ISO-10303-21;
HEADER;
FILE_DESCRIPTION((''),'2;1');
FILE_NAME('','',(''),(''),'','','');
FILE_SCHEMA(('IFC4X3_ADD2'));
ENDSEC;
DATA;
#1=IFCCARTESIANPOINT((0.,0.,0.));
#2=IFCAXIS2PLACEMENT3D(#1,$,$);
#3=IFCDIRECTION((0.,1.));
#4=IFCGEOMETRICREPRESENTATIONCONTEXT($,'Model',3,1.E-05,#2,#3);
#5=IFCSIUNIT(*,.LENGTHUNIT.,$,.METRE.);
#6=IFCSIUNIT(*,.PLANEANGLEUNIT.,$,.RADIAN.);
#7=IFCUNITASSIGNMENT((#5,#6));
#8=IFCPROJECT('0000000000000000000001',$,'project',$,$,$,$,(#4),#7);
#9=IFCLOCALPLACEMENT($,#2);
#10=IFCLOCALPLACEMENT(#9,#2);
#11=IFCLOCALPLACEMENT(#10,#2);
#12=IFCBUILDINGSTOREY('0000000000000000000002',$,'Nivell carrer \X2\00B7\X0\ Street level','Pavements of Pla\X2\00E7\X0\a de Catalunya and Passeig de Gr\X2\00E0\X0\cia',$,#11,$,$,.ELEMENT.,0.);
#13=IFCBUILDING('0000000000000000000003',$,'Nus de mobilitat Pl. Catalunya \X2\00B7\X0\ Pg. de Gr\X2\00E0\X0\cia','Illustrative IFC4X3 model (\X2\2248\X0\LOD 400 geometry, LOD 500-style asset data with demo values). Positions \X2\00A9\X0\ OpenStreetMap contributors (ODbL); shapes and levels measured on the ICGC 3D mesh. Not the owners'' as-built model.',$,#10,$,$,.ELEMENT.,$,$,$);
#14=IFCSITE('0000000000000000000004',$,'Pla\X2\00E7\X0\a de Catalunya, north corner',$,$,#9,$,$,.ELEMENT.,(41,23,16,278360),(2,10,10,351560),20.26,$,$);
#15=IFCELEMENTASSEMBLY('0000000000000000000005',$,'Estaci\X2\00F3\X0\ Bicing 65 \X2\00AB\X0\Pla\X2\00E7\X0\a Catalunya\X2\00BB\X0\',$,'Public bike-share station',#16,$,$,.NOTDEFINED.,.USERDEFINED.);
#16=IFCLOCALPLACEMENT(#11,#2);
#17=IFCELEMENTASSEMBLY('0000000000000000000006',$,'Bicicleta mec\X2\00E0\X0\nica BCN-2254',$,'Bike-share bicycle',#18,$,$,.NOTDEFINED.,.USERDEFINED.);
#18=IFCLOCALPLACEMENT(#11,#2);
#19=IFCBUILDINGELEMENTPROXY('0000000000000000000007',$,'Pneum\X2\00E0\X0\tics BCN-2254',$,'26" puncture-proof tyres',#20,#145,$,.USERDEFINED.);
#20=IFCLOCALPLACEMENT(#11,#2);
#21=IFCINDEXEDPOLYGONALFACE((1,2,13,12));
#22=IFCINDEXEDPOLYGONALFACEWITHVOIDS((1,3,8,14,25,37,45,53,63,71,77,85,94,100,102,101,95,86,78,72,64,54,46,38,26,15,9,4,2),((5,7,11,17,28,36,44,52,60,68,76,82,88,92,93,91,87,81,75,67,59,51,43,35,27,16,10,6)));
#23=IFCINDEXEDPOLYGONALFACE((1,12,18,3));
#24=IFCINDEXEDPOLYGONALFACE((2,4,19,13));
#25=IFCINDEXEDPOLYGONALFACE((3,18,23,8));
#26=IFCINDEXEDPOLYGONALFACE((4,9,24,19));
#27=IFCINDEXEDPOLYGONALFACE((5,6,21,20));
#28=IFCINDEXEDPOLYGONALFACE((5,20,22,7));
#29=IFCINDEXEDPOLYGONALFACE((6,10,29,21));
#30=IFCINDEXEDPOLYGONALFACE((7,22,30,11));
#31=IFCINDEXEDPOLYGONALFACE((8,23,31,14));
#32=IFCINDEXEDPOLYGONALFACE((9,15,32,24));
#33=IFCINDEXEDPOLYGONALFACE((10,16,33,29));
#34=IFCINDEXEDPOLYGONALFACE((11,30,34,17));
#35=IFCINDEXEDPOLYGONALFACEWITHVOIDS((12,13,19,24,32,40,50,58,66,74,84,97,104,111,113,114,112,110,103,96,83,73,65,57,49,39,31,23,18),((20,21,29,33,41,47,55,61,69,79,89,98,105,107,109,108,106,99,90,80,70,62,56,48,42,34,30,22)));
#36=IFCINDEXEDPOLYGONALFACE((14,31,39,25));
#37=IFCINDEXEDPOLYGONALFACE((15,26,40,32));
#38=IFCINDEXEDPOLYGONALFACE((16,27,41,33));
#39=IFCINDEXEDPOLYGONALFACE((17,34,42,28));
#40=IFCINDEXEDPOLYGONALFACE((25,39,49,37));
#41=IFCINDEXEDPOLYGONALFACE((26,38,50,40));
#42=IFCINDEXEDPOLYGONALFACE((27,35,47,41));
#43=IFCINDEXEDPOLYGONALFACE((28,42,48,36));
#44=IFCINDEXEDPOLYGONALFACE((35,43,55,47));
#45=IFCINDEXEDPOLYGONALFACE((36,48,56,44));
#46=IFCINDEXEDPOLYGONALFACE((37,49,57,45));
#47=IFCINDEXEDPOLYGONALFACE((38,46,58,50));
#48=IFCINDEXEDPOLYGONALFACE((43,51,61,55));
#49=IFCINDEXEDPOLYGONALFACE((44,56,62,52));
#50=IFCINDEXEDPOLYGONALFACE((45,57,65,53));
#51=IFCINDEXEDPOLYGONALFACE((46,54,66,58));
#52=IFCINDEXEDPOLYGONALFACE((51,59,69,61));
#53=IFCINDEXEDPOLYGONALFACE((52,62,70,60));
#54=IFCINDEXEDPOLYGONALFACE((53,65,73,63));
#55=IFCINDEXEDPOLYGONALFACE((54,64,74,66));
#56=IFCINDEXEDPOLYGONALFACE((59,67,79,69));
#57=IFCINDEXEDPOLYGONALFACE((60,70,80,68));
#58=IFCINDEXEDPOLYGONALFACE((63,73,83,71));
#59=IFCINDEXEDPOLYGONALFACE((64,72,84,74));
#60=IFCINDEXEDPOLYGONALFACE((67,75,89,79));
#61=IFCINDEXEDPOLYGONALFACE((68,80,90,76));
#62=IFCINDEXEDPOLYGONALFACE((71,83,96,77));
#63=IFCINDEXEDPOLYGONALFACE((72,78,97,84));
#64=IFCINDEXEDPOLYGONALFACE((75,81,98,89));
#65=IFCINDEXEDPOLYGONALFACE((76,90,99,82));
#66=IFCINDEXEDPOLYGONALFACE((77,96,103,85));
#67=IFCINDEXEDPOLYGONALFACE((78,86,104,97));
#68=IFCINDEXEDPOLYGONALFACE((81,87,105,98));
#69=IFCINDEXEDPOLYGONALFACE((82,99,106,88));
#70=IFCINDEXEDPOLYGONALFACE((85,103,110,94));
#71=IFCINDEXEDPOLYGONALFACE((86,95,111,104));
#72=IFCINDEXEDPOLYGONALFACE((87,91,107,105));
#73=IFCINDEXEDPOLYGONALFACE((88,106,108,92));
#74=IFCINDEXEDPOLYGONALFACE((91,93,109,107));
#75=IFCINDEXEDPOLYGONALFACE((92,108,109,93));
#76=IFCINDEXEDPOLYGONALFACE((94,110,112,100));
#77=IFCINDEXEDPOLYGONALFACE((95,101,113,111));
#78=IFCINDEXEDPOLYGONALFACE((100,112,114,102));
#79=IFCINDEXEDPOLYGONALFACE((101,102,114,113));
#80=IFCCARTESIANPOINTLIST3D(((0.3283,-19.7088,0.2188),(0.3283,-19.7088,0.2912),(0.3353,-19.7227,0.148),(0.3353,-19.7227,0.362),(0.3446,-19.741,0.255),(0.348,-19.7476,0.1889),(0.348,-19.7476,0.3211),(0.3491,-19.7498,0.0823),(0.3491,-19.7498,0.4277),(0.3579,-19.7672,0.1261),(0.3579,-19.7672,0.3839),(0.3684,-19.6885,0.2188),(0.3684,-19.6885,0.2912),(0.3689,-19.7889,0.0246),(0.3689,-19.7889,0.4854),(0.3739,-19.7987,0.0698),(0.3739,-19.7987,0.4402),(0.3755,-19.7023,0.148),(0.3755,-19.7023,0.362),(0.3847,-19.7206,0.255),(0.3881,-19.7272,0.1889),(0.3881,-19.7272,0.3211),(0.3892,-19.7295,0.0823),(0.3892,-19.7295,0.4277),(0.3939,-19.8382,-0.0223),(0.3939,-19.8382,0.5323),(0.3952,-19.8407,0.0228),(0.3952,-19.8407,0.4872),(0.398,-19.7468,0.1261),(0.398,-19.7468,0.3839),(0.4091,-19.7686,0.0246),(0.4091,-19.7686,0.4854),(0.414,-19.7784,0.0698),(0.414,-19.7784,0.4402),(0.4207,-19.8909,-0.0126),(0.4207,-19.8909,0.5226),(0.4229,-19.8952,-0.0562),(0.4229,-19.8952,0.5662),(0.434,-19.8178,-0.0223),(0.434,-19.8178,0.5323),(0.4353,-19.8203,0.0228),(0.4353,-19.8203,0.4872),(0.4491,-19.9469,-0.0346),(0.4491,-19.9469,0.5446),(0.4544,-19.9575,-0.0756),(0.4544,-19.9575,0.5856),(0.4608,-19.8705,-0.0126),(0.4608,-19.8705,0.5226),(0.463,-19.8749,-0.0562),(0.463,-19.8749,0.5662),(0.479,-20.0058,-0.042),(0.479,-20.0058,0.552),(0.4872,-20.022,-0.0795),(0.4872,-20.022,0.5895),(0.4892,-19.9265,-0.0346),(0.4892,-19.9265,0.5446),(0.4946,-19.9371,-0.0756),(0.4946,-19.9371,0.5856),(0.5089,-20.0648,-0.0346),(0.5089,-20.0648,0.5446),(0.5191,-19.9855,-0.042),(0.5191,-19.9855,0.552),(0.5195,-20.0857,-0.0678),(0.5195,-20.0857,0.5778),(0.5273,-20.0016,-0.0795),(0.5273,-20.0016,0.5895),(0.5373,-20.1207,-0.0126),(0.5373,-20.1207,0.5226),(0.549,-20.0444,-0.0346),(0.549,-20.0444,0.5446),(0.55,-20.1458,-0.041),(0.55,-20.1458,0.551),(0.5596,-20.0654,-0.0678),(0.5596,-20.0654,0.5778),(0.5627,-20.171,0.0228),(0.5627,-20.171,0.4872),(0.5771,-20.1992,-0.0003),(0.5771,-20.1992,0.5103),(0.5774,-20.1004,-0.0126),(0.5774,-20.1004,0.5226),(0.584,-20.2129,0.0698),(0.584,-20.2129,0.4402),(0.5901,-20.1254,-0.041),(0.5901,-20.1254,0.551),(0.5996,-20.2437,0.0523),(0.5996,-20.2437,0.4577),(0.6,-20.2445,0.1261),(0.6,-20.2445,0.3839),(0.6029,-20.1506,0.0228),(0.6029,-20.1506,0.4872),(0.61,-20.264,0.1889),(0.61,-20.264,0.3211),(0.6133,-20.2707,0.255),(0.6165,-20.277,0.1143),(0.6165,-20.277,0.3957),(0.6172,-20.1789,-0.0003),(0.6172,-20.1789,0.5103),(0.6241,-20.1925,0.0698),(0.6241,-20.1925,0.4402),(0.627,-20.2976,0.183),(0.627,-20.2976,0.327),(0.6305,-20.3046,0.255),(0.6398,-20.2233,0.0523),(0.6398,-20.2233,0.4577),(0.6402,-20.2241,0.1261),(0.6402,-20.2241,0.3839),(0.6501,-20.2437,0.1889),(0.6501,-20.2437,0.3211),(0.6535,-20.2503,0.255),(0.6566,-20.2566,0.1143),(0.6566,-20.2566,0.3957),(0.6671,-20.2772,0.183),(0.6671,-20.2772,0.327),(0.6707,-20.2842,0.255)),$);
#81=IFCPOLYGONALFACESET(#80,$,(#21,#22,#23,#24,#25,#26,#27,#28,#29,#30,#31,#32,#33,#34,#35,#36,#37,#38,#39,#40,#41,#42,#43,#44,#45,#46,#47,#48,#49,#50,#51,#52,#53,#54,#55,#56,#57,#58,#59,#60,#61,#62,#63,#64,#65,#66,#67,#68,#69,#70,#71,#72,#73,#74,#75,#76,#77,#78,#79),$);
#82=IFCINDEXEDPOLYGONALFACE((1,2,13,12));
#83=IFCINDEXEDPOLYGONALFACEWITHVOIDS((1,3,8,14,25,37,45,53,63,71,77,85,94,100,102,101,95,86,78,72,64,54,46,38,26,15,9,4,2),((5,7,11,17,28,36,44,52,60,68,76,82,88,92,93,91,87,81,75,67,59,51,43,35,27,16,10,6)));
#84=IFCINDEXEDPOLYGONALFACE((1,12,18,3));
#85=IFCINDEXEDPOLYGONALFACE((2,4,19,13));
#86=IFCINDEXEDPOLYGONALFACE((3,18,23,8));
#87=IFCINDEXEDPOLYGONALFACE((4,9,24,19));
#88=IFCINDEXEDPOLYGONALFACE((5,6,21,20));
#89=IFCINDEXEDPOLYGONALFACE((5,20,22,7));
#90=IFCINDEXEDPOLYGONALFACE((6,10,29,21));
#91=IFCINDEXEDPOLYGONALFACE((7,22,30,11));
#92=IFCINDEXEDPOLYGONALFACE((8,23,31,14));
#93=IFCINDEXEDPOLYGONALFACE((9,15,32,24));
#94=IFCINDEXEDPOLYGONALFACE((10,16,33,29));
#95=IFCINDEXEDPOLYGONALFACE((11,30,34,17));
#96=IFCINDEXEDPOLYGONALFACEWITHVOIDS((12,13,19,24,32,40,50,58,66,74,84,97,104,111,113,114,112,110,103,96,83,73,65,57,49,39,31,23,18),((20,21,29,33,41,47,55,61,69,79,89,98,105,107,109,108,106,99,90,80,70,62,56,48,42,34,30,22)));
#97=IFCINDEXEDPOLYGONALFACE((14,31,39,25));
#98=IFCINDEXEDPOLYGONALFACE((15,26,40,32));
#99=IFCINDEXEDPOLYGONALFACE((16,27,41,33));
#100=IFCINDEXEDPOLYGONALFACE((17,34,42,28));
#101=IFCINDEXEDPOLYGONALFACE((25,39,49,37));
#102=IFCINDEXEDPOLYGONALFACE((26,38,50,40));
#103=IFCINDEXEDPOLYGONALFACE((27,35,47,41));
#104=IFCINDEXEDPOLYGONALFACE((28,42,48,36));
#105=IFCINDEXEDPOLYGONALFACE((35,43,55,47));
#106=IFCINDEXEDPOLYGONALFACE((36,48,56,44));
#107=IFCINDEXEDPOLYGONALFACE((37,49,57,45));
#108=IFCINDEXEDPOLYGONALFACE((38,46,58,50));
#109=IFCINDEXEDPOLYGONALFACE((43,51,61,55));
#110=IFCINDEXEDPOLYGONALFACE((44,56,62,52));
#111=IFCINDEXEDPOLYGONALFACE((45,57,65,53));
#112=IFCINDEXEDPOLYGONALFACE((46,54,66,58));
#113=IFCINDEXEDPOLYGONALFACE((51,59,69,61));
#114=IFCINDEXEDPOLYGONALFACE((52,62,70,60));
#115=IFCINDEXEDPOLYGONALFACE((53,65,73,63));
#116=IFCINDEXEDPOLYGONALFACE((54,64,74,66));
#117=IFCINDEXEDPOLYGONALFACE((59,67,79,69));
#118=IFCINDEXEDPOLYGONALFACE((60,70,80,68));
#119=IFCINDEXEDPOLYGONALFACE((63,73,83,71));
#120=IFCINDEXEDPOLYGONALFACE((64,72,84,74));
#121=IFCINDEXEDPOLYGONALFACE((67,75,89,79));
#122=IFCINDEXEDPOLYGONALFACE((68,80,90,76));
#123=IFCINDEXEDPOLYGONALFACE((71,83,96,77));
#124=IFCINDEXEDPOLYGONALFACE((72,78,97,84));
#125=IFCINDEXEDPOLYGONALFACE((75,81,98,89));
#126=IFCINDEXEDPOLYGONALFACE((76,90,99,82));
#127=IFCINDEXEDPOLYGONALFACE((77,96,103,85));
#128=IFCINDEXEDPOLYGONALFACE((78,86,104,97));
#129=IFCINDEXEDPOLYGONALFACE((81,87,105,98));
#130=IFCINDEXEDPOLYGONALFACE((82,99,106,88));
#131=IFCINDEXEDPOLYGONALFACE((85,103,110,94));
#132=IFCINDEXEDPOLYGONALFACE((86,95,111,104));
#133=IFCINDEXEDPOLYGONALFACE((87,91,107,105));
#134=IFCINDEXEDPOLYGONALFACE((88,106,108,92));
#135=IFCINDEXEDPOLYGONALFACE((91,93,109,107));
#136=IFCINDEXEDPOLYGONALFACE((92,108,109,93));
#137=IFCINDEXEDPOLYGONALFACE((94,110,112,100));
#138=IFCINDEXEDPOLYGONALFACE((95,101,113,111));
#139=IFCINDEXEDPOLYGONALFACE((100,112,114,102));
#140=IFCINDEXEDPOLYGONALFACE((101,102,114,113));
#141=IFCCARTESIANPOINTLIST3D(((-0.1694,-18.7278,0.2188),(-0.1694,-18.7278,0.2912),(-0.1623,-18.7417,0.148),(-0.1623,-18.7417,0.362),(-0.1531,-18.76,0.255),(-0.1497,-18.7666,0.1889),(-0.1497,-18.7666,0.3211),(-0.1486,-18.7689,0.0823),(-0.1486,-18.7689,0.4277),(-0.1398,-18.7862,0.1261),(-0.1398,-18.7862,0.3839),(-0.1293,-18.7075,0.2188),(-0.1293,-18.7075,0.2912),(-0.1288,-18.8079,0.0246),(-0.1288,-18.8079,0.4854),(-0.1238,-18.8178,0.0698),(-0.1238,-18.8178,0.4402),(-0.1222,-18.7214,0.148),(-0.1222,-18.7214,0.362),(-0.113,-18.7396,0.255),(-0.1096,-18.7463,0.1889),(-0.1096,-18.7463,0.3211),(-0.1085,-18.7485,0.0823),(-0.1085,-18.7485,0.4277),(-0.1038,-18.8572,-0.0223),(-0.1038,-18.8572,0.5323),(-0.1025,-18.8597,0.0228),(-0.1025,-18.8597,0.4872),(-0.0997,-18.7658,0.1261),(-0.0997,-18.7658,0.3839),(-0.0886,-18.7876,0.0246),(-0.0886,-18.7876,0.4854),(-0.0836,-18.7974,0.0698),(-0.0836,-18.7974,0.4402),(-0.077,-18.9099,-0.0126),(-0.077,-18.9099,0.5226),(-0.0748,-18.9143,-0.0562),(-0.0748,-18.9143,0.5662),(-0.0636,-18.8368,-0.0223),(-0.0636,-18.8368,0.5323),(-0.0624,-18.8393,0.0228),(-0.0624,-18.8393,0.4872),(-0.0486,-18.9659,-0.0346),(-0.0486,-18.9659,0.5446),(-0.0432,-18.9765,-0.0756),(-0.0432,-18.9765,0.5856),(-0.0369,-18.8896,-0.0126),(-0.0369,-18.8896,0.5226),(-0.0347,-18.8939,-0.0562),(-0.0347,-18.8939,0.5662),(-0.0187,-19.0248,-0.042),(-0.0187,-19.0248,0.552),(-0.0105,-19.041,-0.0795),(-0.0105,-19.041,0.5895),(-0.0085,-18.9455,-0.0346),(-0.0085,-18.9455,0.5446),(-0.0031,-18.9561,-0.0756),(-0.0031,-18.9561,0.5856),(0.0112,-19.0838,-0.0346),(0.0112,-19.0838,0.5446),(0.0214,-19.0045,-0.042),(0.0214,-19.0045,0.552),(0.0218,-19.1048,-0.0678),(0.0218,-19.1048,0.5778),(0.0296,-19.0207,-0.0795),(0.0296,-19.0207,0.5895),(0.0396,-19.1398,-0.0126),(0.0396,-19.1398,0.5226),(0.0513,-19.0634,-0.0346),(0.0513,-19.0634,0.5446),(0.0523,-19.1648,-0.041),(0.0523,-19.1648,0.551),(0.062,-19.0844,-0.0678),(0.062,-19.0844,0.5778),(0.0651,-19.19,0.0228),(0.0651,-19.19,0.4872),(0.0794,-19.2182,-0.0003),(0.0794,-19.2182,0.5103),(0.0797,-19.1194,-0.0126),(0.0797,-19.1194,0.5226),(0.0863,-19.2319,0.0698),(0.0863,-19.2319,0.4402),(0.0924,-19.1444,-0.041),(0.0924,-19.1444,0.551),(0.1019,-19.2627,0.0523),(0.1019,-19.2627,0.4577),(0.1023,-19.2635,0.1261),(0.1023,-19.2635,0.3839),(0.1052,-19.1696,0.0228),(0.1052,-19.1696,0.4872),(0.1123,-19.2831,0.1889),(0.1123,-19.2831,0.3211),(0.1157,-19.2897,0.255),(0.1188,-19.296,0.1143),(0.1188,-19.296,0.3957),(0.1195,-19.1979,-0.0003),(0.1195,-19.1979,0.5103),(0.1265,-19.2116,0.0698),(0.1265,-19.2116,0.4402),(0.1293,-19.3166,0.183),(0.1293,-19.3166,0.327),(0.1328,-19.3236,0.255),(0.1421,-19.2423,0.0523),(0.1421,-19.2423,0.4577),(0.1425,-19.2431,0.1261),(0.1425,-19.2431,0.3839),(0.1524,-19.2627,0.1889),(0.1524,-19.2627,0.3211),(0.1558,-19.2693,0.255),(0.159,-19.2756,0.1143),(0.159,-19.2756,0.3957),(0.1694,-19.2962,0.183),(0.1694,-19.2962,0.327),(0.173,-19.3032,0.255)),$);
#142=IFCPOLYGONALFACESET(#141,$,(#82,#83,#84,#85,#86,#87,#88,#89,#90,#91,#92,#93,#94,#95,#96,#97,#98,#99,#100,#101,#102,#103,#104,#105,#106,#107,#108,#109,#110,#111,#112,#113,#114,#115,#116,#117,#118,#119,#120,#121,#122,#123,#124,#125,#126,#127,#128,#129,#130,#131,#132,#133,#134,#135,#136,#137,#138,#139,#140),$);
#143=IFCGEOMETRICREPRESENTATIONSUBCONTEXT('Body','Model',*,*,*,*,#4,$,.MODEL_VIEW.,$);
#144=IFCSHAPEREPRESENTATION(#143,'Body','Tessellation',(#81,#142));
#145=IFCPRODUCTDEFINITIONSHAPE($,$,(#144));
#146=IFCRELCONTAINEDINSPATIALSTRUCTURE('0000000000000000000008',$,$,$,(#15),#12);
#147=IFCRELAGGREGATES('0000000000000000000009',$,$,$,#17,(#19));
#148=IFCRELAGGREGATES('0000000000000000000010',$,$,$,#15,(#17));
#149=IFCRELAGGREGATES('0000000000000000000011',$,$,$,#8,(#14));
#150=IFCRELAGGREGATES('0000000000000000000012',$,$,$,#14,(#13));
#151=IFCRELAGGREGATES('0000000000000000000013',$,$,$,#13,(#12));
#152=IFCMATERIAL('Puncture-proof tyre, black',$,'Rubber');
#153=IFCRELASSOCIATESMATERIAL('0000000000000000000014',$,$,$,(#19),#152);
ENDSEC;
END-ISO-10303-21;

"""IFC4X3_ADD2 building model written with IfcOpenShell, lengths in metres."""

from ifc_helpers import new_model, si_unit, direction, frame, origin, origin_2d_with_axis, place, context, subcontext, project, spatial, hollow_circle, extrude, material, element, aggregate, save


model = new_model("IFC4X3_ADD2")

# Units and contexts
model_context = context("Model", 3, precision=1e-05, world=origin(), true_north=direction((0.0, 1.0)))
body_context = subcontext(model_context, "Body", "Model", "MODEL_VIEW")
ifc_project = project(units=[si_unit("LENGTHUNIT", "METRE"), si_unit("PLANEANGLEUNIT", "RADIAN")], contexts=[model_context])

# Site, building, storey
site_placement = place(None, origin())
site = spatial("IfcSite", under=ifc_project, at=site_placement, Name="Plaça de Catalunya, north corner", CompositionType="ELEMENT", RefLatitude=(41, 23, 16, 278360), RefLongitude=(2, 10, 10, 351560), RefElevation=20.26)
building_placement = place(site_placement, origin())
building = spatial("IfcBuilding", under=site, at=building_placement, Name="Nus de mobilitat Pl. Catalunya · Pg. de Gràcia", Description="Illustrative IFC4X3 model (≈LOD 400 geometry, LOD 500-style asset data with demo values). Positions © OpenStreetMap contributors (ODbL); shapes and levels measured on the ICGC 3D mesh. Not the owners' as-built model.", CompositionType="ELEMENT")
storey_placement = place(building_placement, origin())
storey = spatial("IfcBuildingStorey", under=building, at=storey_placement, Name="Nivell carrer · Street level", Description="Pavements of Plaça de Catalunya and Passeig de Gràcia", CompositionType="ELEMENT", Elevation=0.0)

# Element assemblies, building element proxy
assembly_1_placement = place(building_placement, origin())
assembly_1 = element("IfcElementAssembly", 1, at=assembly_1_placement, inside=storey, Name="Estació Bicing 65 «Plaça Catalunya»", ObjectType="Public bike-share station", AssemblyPlace="NOTDEFINED", PredefinedType="USERDEFINED")
assembly_2_placement = place(building_placement, origin())
assembly_2 = element("IfcElementAssembly", 2, at=assembly_2_placement, Name="Bicicleta mecànica BCN-2254", ObjectType="Bike-share bicycle", AssemblyPlace="NOTDEFINED", PredefinedType="USERDEFINED")
ifc_material_1 = material(Name="Puncture-proof tyre, black", Category="Rubber")
proxy_1_placement = place(building_placement, origin())
proxy_1 = element("IfcBuildingElementProxy", 3, at=proxy_1_placement, material=ifc_material_1, Name="Pneumàtics BCN-2254", ObjectType="26\" puncture-proof tyres", PredefinedType="USERDEFINED", context=body_context, shape_type="SweptSolid", body=[
    extrude(hollow_circle(Radius=0.335, WallThickness=0.038, at=origin_2d_with_axis()), frame((0.479, -20.0058, 0.255), z_axis=(0.891798, 0.452435, 0.0), x_axis=(0.452435, -0.891798, 0.0)), (0.0, 0.0, 1.0), 0.045),
    extrude(hollow_circle(Radius=0.335, WallThickness=0.038, at=origin_2d_with_axis()), frame((-0.0187, -19.0248, 0.255), z_axis=(0.891798, 0.452435, 0.0), x_axis=(0.452435, -0.891798, 0.0)), (0.0, 0.0, 1.0), 0.045),
])
aggregate(assembly_2, [proxy_1])
aggregate(assembly_1, [assembly_2])

save(model, "model.ifc")
